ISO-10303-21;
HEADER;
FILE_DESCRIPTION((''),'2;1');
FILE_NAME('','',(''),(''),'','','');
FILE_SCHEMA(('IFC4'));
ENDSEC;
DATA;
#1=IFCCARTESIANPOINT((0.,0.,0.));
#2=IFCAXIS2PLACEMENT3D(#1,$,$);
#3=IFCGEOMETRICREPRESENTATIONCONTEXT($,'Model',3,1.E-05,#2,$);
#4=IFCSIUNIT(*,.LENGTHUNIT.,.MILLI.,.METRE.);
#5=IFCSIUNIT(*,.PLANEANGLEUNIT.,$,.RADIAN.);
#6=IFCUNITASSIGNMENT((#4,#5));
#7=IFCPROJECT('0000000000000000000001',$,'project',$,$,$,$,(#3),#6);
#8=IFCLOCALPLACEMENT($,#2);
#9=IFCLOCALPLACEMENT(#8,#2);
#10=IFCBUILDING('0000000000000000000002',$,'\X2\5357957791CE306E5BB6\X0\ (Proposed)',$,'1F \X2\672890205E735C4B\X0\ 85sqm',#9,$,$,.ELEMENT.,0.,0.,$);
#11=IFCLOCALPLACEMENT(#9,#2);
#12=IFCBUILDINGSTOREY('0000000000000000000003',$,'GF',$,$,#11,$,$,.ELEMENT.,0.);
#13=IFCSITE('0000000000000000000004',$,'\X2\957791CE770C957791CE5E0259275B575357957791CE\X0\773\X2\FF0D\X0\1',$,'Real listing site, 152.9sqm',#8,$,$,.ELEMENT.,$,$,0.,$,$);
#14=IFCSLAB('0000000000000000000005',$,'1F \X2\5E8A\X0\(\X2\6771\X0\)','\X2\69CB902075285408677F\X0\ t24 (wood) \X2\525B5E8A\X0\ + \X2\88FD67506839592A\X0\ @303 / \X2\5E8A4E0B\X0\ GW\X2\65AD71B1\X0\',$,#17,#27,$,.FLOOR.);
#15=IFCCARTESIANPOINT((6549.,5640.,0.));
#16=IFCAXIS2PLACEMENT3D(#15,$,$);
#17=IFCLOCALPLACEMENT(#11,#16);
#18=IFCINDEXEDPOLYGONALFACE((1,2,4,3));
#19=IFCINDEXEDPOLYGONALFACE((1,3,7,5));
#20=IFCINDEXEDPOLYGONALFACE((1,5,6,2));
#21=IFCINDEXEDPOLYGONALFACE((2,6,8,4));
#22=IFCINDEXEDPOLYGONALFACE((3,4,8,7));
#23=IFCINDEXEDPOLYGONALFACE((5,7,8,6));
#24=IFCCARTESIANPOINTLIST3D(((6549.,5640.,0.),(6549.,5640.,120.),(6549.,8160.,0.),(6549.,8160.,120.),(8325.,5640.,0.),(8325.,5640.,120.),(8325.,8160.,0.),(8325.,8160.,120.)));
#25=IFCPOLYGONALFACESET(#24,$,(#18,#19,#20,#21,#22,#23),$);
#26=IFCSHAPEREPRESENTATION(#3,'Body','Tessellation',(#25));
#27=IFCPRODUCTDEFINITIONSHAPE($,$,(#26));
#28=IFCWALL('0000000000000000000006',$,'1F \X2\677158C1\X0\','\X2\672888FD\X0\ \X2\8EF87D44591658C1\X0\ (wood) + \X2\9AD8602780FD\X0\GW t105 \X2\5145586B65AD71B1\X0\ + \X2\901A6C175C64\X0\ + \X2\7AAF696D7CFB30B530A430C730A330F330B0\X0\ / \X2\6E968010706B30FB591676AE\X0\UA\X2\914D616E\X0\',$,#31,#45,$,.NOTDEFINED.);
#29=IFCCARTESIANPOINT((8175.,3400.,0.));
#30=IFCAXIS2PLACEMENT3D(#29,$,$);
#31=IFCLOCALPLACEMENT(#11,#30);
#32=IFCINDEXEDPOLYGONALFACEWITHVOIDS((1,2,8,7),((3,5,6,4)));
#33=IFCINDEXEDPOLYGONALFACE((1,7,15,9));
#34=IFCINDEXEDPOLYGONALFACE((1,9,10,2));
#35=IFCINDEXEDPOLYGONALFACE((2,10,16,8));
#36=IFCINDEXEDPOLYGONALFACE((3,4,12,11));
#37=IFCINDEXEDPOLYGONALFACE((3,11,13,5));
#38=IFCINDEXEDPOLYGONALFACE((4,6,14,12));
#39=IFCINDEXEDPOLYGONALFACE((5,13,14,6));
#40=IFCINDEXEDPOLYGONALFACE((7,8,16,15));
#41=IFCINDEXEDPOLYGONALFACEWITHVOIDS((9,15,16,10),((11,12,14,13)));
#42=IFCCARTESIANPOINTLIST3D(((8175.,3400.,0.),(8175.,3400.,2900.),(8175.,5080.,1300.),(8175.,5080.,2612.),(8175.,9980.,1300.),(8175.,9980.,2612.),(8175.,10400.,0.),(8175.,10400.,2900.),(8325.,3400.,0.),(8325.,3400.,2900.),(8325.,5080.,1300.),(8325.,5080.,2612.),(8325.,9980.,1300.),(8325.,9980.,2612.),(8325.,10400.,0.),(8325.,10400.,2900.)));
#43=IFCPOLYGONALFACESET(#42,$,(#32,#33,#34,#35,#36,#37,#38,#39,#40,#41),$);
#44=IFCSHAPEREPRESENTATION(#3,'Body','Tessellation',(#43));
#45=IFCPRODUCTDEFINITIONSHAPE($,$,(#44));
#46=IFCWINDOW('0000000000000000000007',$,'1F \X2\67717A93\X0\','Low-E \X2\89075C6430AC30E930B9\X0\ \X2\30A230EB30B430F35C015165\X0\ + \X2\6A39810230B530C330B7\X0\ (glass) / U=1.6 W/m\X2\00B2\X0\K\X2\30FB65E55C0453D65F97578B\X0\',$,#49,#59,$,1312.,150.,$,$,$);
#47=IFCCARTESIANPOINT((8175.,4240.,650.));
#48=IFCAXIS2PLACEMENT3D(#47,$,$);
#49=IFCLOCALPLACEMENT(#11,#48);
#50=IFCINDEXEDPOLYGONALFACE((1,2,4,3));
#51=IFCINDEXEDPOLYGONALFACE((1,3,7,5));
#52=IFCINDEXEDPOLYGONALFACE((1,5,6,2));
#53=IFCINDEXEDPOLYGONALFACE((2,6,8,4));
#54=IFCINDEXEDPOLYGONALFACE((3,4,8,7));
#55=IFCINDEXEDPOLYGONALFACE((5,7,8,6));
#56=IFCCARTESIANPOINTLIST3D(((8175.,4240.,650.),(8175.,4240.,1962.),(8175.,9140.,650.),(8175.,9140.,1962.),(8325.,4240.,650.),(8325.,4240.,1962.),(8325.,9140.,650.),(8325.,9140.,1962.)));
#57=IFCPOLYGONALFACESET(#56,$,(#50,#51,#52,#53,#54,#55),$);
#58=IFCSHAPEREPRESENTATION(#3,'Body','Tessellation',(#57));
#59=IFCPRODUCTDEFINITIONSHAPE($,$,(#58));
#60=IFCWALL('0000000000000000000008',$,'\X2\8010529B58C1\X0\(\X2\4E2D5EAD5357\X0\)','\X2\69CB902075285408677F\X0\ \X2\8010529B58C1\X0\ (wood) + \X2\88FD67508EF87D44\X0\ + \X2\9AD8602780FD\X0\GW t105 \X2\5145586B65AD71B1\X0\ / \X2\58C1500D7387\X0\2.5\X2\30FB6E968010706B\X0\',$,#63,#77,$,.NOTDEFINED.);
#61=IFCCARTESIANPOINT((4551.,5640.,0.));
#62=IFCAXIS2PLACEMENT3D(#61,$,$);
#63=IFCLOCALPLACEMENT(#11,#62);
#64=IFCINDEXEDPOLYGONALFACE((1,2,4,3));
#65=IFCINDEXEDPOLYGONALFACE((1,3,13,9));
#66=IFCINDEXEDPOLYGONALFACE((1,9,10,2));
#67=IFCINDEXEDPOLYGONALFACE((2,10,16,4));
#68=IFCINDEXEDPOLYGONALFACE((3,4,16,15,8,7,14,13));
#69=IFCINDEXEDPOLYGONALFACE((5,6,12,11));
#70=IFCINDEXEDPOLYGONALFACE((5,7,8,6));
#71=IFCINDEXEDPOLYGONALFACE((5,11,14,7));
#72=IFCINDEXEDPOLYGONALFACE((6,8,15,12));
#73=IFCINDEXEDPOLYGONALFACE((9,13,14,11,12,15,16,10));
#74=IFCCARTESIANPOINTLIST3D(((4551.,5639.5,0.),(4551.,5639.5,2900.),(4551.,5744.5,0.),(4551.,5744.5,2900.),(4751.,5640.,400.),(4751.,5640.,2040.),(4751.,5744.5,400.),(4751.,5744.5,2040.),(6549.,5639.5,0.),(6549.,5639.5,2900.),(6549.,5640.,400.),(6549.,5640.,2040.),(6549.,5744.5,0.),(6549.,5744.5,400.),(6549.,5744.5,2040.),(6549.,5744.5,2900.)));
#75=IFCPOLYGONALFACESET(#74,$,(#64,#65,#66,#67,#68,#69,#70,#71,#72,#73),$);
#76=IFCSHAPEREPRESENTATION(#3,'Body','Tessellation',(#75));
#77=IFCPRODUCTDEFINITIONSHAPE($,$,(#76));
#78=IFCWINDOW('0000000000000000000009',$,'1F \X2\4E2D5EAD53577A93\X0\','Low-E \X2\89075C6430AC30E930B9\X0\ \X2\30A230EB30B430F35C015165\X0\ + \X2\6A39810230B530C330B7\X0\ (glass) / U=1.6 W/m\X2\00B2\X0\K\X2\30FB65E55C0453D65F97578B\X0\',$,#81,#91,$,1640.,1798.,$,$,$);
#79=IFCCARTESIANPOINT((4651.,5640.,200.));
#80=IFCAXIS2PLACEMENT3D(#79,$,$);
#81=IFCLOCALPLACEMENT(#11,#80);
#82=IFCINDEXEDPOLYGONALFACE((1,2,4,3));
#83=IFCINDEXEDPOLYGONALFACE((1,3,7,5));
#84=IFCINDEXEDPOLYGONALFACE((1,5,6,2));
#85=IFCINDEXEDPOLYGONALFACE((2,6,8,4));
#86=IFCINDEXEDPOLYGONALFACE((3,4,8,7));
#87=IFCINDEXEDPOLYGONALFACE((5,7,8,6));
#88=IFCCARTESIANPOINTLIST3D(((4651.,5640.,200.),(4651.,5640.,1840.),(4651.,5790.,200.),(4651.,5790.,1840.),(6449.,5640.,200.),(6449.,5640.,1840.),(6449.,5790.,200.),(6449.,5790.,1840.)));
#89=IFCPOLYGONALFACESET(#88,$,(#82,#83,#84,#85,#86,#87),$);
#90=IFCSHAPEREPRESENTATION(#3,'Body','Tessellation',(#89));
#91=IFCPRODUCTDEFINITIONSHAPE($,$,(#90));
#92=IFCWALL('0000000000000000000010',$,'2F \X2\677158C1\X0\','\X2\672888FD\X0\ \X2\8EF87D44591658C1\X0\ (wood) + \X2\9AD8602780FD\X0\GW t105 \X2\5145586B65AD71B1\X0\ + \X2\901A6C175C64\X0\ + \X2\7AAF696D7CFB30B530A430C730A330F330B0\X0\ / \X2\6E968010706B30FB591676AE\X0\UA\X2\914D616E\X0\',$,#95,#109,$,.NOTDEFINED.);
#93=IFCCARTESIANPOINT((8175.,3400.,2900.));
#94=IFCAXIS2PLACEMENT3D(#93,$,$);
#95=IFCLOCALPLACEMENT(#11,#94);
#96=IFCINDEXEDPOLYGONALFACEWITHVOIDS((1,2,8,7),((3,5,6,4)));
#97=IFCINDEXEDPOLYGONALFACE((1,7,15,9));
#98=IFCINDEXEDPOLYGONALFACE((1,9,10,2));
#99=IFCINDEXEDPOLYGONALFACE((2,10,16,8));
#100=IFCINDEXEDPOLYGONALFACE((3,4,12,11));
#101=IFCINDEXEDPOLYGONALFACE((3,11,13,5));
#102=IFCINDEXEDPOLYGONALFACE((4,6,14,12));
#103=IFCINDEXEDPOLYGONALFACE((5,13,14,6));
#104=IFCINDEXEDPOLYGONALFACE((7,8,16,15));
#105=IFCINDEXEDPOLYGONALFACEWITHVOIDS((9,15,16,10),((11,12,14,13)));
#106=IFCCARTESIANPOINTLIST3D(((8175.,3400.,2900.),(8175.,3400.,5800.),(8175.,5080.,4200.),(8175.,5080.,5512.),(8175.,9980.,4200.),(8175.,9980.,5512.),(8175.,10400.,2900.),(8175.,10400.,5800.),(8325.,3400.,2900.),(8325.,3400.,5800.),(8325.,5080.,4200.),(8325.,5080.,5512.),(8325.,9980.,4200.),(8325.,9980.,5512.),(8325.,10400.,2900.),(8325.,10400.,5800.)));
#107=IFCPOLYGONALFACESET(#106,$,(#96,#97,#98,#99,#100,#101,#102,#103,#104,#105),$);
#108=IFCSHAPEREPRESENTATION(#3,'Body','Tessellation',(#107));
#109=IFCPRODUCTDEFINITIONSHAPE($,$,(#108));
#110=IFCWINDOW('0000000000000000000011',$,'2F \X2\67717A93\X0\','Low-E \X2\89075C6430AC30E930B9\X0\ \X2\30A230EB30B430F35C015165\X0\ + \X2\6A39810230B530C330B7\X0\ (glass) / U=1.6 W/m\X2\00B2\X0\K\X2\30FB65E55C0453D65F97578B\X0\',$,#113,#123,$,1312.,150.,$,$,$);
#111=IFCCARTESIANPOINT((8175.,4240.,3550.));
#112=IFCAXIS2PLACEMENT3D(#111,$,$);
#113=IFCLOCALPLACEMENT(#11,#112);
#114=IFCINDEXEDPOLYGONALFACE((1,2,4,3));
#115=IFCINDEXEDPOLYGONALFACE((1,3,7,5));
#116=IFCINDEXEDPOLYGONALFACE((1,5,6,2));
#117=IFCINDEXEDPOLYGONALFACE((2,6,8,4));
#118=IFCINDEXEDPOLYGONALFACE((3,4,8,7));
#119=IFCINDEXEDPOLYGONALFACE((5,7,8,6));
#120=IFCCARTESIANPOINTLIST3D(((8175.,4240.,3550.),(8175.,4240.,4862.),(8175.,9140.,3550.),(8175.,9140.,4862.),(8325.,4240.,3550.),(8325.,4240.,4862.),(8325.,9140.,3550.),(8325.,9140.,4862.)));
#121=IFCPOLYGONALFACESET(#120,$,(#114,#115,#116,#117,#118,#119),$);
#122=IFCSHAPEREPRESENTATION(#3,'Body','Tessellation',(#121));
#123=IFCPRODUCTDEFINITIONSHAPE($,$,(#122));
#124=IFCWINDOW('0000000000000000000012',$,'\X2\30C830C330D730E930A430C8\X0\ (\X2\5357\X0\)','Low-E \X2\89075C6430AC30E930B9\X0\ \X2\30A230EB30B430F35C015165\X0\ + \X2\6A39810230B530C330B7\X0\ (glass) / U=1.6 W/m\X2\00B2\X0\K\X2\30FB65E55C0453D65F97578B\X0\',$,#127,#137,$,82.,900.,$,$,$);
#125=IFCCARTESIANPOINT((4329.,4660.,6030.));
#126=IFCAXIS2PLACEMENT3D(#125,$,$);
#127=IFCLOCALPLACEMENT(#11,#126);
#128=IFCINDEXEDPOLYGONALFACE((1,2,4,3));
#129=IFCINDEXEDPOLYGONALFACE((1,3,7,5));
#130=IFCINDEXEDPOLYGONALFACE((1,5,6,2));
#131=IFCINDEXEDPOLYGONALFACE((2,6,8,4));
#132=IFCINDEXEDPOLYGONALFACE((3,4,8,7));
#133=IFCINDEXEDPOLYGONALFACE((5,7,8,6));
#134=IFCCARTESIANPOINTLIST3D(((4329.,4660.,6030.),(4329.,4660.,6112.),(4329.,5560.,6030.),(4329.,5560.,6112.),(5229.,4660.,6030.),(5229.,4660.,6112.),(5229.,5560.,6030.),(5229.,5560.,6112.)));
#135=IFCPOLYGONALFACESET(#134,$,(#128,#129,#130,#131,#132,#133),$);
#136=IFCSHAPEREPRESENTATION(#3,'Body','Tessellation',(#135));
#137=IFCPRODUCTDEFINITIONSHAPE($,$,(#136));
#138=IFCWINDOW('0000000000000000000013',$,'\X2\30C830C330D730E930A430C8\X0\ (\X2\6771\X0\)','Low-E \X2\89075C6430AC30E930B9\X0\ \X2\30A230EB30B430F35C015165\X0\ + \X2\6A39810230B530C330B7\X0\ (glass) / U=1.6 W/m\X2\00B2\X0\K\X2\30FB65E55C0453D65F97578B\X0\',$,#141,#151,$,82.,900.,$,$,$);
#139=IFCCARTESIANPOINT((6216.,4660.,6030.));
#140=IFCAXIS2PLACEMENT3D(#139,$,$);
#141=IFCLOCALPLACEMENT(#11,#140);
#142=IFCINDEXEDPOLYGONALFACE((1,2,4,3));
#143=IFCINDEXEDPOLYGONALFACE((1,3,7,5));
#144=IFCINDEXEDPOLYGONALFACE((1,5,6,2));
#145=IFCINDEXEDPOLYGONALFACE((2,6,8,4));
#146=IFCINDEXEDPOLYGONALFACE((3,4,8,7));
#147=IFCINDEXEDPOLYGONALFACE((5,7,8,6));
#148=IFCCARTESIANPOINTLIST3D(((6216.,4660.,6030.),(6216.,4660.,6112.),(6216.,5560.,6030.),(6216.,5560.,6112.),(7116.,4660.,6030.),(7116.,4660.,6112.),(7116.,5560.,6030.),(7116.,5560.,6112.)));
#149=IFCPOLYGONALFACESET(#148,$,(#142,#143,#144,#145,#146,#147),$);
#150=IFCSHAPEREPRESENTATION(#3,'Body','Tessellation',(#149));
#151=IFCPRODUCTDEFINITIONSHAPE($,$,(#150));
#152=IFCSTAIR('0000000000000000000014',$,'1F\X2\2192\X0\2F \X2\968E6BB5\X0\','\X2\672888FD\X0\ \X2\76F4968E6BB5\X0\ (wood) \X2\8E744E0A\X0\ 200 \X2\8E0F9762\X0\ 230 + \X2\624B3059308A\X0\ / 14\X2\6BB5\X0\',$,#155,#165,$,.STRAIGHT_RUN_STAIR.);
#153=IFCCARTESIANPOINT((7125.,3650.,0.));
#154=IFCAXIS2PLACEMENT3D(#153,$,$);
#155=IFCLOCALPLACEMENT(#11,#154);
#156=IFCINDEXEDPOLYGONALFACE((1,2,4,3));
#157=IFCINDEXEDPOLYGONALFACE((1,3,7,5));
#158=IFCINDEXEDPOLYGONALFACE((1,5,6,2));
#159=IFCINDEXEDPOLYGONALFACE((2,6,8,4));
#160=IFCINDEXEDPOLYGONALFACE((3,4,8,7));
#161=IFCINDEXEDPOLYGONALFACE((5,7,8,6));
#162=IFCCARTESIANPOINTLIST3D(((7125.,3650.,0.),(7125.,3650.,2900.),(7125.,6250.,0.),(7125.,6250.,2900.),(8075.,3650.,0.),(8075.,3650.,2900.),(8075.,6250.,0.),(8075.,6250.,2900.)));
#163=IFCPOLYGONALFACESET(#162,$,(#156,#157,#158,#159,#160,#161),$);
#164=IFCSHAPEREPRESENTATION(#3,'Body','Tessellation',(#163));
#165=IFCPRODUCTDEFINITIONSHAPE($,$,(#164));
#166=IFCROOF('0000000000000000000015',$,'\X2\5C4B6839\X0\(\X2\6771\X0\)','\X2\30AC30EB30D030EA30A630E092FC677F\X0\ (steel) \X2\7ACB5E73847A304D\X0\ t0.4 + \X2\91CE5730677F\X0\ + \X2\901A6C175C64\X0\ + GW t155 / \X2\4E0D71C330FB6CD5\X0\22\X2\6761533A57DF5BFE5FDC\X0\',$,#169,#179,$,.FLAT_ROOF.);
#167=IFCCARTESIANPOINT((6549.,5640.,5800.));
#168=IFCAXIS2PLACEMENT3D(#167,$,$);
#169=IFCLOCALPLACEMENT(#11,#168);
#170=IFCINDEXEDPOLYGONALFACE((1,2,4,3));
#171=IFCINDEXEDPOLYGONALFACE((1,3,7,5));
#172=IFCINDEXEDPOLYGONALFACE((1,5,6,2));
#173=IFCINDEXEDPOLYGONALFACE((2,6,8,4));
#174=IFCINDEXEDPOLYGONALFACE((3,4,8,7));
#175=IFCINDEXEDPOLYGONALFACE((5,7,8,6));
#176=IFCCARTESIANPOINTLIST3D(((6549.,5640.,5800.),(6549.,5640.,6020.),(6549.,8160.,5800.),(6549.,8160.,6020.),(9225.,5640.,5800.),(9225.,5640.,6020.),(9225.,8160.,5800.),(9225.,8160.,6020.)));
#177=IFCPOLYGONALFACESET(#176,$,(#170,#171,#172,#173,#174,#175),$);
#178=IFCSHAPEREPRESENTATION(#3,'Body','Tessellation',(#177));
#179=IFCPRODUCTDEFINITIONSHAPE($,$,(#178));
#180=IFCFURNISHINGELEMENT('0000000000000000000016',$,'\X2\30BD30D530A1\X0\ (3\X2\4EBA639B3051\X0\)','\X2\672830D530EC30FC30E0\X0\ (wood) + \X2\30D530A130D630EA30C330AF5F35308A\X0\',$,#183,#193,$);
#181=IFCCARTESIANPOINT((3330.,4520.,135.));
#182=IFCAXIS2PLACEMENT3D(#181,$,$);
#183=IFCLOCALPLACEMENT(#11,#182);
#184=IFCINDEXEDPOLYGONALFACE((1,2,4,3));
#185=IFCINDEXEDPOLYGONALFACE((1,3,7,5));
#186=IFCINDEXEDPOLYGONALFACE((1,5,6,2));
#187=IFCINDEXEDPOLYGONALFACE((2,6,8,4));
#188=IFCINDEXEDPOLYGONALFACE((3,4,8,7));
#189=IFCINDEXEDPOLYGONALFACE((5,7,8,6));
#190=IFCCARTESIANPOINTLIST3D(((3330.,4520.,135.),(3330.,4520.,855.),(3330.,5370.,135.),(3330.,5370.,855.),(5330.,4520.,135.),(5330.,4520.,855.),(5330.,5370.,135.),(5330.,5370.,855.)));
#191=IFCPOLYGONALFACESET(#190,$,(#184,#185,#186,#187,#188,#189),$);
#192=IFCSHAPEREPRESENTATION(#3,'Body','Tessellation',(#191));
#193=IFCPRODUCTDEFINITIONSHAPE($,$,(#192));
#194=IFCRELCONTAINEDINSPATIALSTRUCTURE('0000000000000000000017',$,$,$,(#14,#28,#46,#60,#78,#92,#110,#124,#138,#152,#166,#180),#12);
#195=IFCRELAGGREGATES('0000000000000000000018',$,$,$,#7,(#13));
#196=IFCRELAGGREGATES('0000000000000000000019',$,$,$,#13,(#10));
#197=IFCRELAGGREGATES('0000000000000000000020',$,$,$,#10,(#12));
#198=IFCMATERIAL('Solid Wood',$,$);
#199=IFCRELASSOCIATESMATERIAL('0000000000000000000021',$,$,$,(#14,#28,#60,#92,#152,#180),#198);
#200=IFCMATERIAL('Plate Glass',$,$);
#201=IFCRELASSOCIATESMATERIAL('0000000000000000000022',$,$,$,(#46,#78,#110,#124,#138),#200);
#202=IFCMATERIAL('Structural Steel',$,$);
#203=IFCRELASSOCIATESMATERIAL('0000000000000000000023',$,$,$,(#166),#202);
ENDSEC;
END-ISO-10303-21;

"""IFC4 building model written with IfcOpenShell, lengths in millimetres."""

from ifc_helpers import new_model, si_unit, frame, frame_2d, origin, place, context, project, spatial, rectangle, extrude, material, element, fill, save


model = new_model("IFC4")

# Units and contexts
model_context = context("Model", 3, precision=1e-05, world=origin())
ifc_project = project(units=[si_unit("LENGTHUNIT", "METRE", prefix="MILLI"), si_unit("PLANEANGLEUNIT", "RADIAN")], contexts=[model_context])

# Site, building, storey
site_placement = place(None, origin())
site = spatial("IfcSite", under=ifc_project, at=site_placement, Name="長野県長野市大字南長野773－1", ObjectType="Real listing site, 152.9sqm", CompositionType="ELEMENT", RefElevation=0.0)
building_placement = place(site_placement, origin())
building = spatial("IfcBuilding", under=site, at=building_placement, Name="南長野の家 (Proposed)", ObjectType="1F 木造平屋 85sqm", CompositionType="ELEMENT", ElevationOfRefHeight=0.0, ElevationOfTerrain=0.0)
storey_placement = place(building_placement, origin())
storey = spatial("IfcBuildingStorey", under=building, at=storey_placement, Name="GF", CompositionType="ELEMENT", Elevation=0.0)

# Slab
ifc_material_1 = material(Name="Solid Wood")
slab_placement = place(storey_placement, frame((6549.0, 5640.0, 0.0)))
element("IfcSlab", 1, at=slab_placement, inside=storey, material=ifc_material_1, Name="1F 床(東)", Description="構造用合板 t24 (wood) 剛床 + 製材根太 @303 / 床下 GW断熱", PredefinedType="FLOOR", context=model_context, shape_type="SweptSolid", body=[
    extrude(rectangle(XDim=1776.0, YDim=2520.0, at=frame_2d((888.0, 1260.0))), frame((6549.0, 5640.0, 0.0)), (0.0, 0.0, 1.0), 120.0),
])

# Walls, openings, windows
wall_1_placement = place(storey_placement, frame((8175.0, 3400.0, 0.0)))
wall_1 = element("IfcWall", 2, at=wall_1_placement, inside=storey, material=ifc_material_1, Name="1F 東壁", Description="木製 軸組外壁 (wood) + 高性能GW t105 充填断熱 + 通気層 + 窯業系サイディング / 準耐火・外皮UA配慮", PredefinedType="NOTDEFINED", context=model_context, shape_type="SweptSolid", body=[
    extrude(rectangle(XDim=150.0, YDim=7000.0, at=frame_2d((75.0, 3500.0))), frame((8175.0, 3400.0, 0.0)), (0.0, 0.0, 1.0), 2900.0),
])
opening_1_placement = place(storey_placement, frame((8175.0, 4240.0, 650.0)))
opening_1 = element("IfcOpeningElement", 3, at=opening_1_placement, cuts=wall_1, PredefinedType="NOTDEFINED", context=model_context, shape_type="SweptSolid", body=[
    extrude(rectangle(XDim=150.0, YDim=4900.0, at=frame_2d((75.0, 2450.0))), frame((8175.0, 4240.0, 650.0)), (0.0, 0.0, 1.0), 1312.0),
])
ifc_material_2 = material(Name="Plate Glass")
window_1_placement = place(storey_placement, frame((8175.0, 4240.0, 650.0)))
window_1 = element("IfcWindow", 4, at=window_1_placement, inside=storey, material=ifc_material_2, Name="1F 東窓", Description="Low-E 複層ガラス アルゴン封入 + 樹脂サッシ (glass) / U=1.6 W/m²K・日射取得型", OverallHeight=1312.0, OverallWidth=150.0, context=model_context, shape_type="SweptSolid", body=[
    extrude(rectangle(XDim=150.0, YDim=4900.0, at=frame_2d((75.0, 2450.0))), frame((8175.0, 4240.0, 650.0)), (0.0, 0.0, 1.0), 1312.0),
])
fill(opening_1, window_1)
wall_2_placement = place(storey_placement, frame((4551.0, 5640.0, 0.0)))
wall_2 = element("IfcWall", 5, at=wall_2_placement, inside=storey, material=ifc_material_1, Name="耐力壁(中庭南)", Description="構造用合板 耐力壁 (wood) + 製材軸組 + 高性能GW t105 充填断熱 / 壁倍率2.5・準耐火", PredefinedType="NOTDEFINED", context=model_context, shape_type="SweptSolid", body=[
    extrude(rectangle(XDim=1998.0, YDim=105.0, at=frame_2d((999.0, 52.0))), frame((4551.0, 5640.0, 0.0)), (0.0, 0.0, 1.0), 2900.0),
])
opening_2_placement = place(storey_placement, frame((4651.0, 5640.0, 200.0)))
opening_2 = element("IfcOpeningElement", 6, at=opening_2_placement, cuts=wall_2, PredefinedType="NOTDEFINED", context=model_context, shape_type="SweptSolid", body=[
    extrude(rectangle(XDim=1798.0, YDim=150.0, at=frame_2d((899.0, 75.0))), frame((4651.0, 5640.0, 200.0)), (0.0, 0.0, 1.0), 1640.0),
])
window_2_placement = place(storey_placement, frame((4651.0, 5640.0, 200.0)))
window_2 = element("IfcWindow", 7, at=window_2_placement, inside=storey, material=ifc_material_2, Name="1F 中庭南窓", Description="Low-E 複層ガラス アルゴン封入 + 樹脂サッシ (glass) / U=1.6 W/m²K・日射取得型", OverallHeight=1640.0, OverallWidth=1798.0, context=model_context, shape_type="SweptSolid", body=[
    extrude(rectangle(XDim=1798.0, YDim=150.0, at=frame_2d((899.0, 75.0))), frame((4651.0, 5640.0, 200.0)), (0.0, 0.0, 1.0), 1640.0),
])
fill(opening_2, window_2)

# Wall, opening, window
wall_3_placement = place(storey_placement, frame((8175.0, 3400.0, 2900.0)))
wall_3 = element("IfcWall", 8, at=wall_3_placement, inside=storey, material=ifc_material_1, Name="2F 東壁", Description="木製 軸組外壁 (wood) + 高性能GW t105 充填断熱 + 通気層 + 窯業系サイディング / 準耐火・外皮UA配慮", PredefinedType="NOTDEFINED", context=model_context, shape_type="SweptSolid", body=[
    extrude(rectangle(XDim=150.0, YDim=7000.0, at=frame_2d((75.0, 3500.0))), frame((8175.0, 3400.0, 2900.0)), (0.0, 0.0, 1.0), 2900.0),
])
opening_3_placement = place(storey_placement, frame((8175.0, 4240.0, 3550.0)))
opening_3 = element("IfcOpeningElement", 9, at=opening_3_placement, cuts=wall_3, PredefinedType="NOTDEFINED", context=model_context, shape_type="SweptSolid", body=[
    extrude(rectangle(XDim=150.0, YDim=4900.0, at=frame_2d((75.0, 2450.0))), frame((8175.0, 4240.0, 3550.0)), (0.0, 0.0, 1.0), 1312.0),
])
window_3_placement = place(storey_placement, frame((8175.0, 4240.0, 3550.0)))
window_3 = element("IfcWindow", 10, at=window_3_placement, inside=storey, material=ifc_material_2, Name="2F 東窓", Description="Low-E 複層ガラス アルゴン封入 + 樹脂サッシ (glass) / U=1.6 W/m²K・日射取得型", OverallHeight=1312.0, OverallWidth=150.0, context=model_context, shape_type="SweptSolid", body=[
    extrude(rectangle(XDim=150.0, YDim=4900.0, at=frame_2d((75.0, 2450.0))), frame((8175.0, 4240.0, 3550.0)), (0.0, 0.0, 1.0), 1312.0),
])
fill(opening_3, window_3)

# Windows
window_4_placement = place(storey_placement, frame((4329.0, 4660.0, 6030.0)))
element("IfcWindow", 11, at=window_4_placement, inside=storey, material=ifc_material_2, Name="トップライト (南)", Description="Low-E 複層ガラス アルゴン封入 + 樹脂サッシ (glass) / U=1.6 W/m²K・日射取得型", OverallHeight=82.0, OverallWidth=900.0, context=model_context, shape_type="SweptSolid", body=[
    extrude(rectangle(XDim=900.0, YDim=900.0, at=frame_2d((450.0, 450.0))), frame((4329.0, 4660.0, 6030.0)), (0.0, 0.0, 1.0), 82.0),
])
window_5_placement = place(storey_placement, frame((6216.0, 4660.0, 6030.0)))
element("IfcWindow", 12, at=window_5_placement, inside=storey, material=ifc_material_2, Name="トップライト (東)", Description="Low-E 複層ガラス アルゴン封入 + 樹脂サッシ (glass) / U=1.6 W/m²K・日射取得型", OverallHeight=82.0, OverallWidth=900.0, context=model_context, shape_type="SweptSolid", body=[
    extrude(rectangle(XDim=900.0, YDim=900.0, at=frame_2d((450.0, 450.0))), frame((6216.0, 4660.0, 6030.0)), (0.0, 0.0, 1.0), 82.0),
])

# Stair
stair_placement = place(storey_placement, frame((7125.0, 3650.0, 0.0)))
element("IfcStair", 13, at=stair_placement, inside=storey, material=ifc_material_1, Name="1F→2F 階段", Description="木製 直階段 (wood) 蹴上 200 踏面 230 + 手すり / 14段", PredefinedType="STRAIGHT_RUN_STAIR", context=model_context, shape_type="SweptSolid", body=[
    extrude(rectangle(XDim=950.0, YDim=2600.0, at=frame_2d((475.0, 1300.0))), frame((7125.0, 3650.0, 0.0)), (0.0, 0.0, 1.0), 2900.0),
])

# Roof
ifc_material_3 = material(Name="Structural Steel")
roof_placement = place(storey_placement, frame((6549.0, 5640.0, 5800.0)))
element("IfcRoof", 14, at=roof_placement, inside=storey, material=ifc_material_3, Name="屋根(東)", Description="ガルバリウム鋼板 (steel) 立平葺き t0.4 + 野地板 + 通気層 + GW t155 / 不燃・法22条区域対応", PredefinedType="FLAT_ROOF", context=model_context, shape_type="SweptSolid", body=[
    extrude(rectangle(XDim=2676.0, YDim=2520.0, at=frame_2d((1338.0, 1260.0))), frame((6549.0, 5640.0, 5800.0)), (0.0, 0.0, 1.0), 220.0),
])

# Furnishing element
furnishing_1_placement = place(storey_placement, frame((3330.0, 4520.0, 135.0)))
element("IfcFurnishingElement", 15, at=furnishing_1_placement, inside=storey, material=ifc_material_1, Name="ソファ (3人掛け)", Description="木フレーム (wood) + ファブリック張り", context=model_context, shape_type="SweptSolid", body=[
    extrude(rectangle(XDim=2000.0, YDim=850.0, at=frame_2d((1000.0, 425.0))), frame((3330.0, 4520.0, 135.0)), (0.0, 0.0, 1.0), 720.0),
])

save(model, "model.ifc")
